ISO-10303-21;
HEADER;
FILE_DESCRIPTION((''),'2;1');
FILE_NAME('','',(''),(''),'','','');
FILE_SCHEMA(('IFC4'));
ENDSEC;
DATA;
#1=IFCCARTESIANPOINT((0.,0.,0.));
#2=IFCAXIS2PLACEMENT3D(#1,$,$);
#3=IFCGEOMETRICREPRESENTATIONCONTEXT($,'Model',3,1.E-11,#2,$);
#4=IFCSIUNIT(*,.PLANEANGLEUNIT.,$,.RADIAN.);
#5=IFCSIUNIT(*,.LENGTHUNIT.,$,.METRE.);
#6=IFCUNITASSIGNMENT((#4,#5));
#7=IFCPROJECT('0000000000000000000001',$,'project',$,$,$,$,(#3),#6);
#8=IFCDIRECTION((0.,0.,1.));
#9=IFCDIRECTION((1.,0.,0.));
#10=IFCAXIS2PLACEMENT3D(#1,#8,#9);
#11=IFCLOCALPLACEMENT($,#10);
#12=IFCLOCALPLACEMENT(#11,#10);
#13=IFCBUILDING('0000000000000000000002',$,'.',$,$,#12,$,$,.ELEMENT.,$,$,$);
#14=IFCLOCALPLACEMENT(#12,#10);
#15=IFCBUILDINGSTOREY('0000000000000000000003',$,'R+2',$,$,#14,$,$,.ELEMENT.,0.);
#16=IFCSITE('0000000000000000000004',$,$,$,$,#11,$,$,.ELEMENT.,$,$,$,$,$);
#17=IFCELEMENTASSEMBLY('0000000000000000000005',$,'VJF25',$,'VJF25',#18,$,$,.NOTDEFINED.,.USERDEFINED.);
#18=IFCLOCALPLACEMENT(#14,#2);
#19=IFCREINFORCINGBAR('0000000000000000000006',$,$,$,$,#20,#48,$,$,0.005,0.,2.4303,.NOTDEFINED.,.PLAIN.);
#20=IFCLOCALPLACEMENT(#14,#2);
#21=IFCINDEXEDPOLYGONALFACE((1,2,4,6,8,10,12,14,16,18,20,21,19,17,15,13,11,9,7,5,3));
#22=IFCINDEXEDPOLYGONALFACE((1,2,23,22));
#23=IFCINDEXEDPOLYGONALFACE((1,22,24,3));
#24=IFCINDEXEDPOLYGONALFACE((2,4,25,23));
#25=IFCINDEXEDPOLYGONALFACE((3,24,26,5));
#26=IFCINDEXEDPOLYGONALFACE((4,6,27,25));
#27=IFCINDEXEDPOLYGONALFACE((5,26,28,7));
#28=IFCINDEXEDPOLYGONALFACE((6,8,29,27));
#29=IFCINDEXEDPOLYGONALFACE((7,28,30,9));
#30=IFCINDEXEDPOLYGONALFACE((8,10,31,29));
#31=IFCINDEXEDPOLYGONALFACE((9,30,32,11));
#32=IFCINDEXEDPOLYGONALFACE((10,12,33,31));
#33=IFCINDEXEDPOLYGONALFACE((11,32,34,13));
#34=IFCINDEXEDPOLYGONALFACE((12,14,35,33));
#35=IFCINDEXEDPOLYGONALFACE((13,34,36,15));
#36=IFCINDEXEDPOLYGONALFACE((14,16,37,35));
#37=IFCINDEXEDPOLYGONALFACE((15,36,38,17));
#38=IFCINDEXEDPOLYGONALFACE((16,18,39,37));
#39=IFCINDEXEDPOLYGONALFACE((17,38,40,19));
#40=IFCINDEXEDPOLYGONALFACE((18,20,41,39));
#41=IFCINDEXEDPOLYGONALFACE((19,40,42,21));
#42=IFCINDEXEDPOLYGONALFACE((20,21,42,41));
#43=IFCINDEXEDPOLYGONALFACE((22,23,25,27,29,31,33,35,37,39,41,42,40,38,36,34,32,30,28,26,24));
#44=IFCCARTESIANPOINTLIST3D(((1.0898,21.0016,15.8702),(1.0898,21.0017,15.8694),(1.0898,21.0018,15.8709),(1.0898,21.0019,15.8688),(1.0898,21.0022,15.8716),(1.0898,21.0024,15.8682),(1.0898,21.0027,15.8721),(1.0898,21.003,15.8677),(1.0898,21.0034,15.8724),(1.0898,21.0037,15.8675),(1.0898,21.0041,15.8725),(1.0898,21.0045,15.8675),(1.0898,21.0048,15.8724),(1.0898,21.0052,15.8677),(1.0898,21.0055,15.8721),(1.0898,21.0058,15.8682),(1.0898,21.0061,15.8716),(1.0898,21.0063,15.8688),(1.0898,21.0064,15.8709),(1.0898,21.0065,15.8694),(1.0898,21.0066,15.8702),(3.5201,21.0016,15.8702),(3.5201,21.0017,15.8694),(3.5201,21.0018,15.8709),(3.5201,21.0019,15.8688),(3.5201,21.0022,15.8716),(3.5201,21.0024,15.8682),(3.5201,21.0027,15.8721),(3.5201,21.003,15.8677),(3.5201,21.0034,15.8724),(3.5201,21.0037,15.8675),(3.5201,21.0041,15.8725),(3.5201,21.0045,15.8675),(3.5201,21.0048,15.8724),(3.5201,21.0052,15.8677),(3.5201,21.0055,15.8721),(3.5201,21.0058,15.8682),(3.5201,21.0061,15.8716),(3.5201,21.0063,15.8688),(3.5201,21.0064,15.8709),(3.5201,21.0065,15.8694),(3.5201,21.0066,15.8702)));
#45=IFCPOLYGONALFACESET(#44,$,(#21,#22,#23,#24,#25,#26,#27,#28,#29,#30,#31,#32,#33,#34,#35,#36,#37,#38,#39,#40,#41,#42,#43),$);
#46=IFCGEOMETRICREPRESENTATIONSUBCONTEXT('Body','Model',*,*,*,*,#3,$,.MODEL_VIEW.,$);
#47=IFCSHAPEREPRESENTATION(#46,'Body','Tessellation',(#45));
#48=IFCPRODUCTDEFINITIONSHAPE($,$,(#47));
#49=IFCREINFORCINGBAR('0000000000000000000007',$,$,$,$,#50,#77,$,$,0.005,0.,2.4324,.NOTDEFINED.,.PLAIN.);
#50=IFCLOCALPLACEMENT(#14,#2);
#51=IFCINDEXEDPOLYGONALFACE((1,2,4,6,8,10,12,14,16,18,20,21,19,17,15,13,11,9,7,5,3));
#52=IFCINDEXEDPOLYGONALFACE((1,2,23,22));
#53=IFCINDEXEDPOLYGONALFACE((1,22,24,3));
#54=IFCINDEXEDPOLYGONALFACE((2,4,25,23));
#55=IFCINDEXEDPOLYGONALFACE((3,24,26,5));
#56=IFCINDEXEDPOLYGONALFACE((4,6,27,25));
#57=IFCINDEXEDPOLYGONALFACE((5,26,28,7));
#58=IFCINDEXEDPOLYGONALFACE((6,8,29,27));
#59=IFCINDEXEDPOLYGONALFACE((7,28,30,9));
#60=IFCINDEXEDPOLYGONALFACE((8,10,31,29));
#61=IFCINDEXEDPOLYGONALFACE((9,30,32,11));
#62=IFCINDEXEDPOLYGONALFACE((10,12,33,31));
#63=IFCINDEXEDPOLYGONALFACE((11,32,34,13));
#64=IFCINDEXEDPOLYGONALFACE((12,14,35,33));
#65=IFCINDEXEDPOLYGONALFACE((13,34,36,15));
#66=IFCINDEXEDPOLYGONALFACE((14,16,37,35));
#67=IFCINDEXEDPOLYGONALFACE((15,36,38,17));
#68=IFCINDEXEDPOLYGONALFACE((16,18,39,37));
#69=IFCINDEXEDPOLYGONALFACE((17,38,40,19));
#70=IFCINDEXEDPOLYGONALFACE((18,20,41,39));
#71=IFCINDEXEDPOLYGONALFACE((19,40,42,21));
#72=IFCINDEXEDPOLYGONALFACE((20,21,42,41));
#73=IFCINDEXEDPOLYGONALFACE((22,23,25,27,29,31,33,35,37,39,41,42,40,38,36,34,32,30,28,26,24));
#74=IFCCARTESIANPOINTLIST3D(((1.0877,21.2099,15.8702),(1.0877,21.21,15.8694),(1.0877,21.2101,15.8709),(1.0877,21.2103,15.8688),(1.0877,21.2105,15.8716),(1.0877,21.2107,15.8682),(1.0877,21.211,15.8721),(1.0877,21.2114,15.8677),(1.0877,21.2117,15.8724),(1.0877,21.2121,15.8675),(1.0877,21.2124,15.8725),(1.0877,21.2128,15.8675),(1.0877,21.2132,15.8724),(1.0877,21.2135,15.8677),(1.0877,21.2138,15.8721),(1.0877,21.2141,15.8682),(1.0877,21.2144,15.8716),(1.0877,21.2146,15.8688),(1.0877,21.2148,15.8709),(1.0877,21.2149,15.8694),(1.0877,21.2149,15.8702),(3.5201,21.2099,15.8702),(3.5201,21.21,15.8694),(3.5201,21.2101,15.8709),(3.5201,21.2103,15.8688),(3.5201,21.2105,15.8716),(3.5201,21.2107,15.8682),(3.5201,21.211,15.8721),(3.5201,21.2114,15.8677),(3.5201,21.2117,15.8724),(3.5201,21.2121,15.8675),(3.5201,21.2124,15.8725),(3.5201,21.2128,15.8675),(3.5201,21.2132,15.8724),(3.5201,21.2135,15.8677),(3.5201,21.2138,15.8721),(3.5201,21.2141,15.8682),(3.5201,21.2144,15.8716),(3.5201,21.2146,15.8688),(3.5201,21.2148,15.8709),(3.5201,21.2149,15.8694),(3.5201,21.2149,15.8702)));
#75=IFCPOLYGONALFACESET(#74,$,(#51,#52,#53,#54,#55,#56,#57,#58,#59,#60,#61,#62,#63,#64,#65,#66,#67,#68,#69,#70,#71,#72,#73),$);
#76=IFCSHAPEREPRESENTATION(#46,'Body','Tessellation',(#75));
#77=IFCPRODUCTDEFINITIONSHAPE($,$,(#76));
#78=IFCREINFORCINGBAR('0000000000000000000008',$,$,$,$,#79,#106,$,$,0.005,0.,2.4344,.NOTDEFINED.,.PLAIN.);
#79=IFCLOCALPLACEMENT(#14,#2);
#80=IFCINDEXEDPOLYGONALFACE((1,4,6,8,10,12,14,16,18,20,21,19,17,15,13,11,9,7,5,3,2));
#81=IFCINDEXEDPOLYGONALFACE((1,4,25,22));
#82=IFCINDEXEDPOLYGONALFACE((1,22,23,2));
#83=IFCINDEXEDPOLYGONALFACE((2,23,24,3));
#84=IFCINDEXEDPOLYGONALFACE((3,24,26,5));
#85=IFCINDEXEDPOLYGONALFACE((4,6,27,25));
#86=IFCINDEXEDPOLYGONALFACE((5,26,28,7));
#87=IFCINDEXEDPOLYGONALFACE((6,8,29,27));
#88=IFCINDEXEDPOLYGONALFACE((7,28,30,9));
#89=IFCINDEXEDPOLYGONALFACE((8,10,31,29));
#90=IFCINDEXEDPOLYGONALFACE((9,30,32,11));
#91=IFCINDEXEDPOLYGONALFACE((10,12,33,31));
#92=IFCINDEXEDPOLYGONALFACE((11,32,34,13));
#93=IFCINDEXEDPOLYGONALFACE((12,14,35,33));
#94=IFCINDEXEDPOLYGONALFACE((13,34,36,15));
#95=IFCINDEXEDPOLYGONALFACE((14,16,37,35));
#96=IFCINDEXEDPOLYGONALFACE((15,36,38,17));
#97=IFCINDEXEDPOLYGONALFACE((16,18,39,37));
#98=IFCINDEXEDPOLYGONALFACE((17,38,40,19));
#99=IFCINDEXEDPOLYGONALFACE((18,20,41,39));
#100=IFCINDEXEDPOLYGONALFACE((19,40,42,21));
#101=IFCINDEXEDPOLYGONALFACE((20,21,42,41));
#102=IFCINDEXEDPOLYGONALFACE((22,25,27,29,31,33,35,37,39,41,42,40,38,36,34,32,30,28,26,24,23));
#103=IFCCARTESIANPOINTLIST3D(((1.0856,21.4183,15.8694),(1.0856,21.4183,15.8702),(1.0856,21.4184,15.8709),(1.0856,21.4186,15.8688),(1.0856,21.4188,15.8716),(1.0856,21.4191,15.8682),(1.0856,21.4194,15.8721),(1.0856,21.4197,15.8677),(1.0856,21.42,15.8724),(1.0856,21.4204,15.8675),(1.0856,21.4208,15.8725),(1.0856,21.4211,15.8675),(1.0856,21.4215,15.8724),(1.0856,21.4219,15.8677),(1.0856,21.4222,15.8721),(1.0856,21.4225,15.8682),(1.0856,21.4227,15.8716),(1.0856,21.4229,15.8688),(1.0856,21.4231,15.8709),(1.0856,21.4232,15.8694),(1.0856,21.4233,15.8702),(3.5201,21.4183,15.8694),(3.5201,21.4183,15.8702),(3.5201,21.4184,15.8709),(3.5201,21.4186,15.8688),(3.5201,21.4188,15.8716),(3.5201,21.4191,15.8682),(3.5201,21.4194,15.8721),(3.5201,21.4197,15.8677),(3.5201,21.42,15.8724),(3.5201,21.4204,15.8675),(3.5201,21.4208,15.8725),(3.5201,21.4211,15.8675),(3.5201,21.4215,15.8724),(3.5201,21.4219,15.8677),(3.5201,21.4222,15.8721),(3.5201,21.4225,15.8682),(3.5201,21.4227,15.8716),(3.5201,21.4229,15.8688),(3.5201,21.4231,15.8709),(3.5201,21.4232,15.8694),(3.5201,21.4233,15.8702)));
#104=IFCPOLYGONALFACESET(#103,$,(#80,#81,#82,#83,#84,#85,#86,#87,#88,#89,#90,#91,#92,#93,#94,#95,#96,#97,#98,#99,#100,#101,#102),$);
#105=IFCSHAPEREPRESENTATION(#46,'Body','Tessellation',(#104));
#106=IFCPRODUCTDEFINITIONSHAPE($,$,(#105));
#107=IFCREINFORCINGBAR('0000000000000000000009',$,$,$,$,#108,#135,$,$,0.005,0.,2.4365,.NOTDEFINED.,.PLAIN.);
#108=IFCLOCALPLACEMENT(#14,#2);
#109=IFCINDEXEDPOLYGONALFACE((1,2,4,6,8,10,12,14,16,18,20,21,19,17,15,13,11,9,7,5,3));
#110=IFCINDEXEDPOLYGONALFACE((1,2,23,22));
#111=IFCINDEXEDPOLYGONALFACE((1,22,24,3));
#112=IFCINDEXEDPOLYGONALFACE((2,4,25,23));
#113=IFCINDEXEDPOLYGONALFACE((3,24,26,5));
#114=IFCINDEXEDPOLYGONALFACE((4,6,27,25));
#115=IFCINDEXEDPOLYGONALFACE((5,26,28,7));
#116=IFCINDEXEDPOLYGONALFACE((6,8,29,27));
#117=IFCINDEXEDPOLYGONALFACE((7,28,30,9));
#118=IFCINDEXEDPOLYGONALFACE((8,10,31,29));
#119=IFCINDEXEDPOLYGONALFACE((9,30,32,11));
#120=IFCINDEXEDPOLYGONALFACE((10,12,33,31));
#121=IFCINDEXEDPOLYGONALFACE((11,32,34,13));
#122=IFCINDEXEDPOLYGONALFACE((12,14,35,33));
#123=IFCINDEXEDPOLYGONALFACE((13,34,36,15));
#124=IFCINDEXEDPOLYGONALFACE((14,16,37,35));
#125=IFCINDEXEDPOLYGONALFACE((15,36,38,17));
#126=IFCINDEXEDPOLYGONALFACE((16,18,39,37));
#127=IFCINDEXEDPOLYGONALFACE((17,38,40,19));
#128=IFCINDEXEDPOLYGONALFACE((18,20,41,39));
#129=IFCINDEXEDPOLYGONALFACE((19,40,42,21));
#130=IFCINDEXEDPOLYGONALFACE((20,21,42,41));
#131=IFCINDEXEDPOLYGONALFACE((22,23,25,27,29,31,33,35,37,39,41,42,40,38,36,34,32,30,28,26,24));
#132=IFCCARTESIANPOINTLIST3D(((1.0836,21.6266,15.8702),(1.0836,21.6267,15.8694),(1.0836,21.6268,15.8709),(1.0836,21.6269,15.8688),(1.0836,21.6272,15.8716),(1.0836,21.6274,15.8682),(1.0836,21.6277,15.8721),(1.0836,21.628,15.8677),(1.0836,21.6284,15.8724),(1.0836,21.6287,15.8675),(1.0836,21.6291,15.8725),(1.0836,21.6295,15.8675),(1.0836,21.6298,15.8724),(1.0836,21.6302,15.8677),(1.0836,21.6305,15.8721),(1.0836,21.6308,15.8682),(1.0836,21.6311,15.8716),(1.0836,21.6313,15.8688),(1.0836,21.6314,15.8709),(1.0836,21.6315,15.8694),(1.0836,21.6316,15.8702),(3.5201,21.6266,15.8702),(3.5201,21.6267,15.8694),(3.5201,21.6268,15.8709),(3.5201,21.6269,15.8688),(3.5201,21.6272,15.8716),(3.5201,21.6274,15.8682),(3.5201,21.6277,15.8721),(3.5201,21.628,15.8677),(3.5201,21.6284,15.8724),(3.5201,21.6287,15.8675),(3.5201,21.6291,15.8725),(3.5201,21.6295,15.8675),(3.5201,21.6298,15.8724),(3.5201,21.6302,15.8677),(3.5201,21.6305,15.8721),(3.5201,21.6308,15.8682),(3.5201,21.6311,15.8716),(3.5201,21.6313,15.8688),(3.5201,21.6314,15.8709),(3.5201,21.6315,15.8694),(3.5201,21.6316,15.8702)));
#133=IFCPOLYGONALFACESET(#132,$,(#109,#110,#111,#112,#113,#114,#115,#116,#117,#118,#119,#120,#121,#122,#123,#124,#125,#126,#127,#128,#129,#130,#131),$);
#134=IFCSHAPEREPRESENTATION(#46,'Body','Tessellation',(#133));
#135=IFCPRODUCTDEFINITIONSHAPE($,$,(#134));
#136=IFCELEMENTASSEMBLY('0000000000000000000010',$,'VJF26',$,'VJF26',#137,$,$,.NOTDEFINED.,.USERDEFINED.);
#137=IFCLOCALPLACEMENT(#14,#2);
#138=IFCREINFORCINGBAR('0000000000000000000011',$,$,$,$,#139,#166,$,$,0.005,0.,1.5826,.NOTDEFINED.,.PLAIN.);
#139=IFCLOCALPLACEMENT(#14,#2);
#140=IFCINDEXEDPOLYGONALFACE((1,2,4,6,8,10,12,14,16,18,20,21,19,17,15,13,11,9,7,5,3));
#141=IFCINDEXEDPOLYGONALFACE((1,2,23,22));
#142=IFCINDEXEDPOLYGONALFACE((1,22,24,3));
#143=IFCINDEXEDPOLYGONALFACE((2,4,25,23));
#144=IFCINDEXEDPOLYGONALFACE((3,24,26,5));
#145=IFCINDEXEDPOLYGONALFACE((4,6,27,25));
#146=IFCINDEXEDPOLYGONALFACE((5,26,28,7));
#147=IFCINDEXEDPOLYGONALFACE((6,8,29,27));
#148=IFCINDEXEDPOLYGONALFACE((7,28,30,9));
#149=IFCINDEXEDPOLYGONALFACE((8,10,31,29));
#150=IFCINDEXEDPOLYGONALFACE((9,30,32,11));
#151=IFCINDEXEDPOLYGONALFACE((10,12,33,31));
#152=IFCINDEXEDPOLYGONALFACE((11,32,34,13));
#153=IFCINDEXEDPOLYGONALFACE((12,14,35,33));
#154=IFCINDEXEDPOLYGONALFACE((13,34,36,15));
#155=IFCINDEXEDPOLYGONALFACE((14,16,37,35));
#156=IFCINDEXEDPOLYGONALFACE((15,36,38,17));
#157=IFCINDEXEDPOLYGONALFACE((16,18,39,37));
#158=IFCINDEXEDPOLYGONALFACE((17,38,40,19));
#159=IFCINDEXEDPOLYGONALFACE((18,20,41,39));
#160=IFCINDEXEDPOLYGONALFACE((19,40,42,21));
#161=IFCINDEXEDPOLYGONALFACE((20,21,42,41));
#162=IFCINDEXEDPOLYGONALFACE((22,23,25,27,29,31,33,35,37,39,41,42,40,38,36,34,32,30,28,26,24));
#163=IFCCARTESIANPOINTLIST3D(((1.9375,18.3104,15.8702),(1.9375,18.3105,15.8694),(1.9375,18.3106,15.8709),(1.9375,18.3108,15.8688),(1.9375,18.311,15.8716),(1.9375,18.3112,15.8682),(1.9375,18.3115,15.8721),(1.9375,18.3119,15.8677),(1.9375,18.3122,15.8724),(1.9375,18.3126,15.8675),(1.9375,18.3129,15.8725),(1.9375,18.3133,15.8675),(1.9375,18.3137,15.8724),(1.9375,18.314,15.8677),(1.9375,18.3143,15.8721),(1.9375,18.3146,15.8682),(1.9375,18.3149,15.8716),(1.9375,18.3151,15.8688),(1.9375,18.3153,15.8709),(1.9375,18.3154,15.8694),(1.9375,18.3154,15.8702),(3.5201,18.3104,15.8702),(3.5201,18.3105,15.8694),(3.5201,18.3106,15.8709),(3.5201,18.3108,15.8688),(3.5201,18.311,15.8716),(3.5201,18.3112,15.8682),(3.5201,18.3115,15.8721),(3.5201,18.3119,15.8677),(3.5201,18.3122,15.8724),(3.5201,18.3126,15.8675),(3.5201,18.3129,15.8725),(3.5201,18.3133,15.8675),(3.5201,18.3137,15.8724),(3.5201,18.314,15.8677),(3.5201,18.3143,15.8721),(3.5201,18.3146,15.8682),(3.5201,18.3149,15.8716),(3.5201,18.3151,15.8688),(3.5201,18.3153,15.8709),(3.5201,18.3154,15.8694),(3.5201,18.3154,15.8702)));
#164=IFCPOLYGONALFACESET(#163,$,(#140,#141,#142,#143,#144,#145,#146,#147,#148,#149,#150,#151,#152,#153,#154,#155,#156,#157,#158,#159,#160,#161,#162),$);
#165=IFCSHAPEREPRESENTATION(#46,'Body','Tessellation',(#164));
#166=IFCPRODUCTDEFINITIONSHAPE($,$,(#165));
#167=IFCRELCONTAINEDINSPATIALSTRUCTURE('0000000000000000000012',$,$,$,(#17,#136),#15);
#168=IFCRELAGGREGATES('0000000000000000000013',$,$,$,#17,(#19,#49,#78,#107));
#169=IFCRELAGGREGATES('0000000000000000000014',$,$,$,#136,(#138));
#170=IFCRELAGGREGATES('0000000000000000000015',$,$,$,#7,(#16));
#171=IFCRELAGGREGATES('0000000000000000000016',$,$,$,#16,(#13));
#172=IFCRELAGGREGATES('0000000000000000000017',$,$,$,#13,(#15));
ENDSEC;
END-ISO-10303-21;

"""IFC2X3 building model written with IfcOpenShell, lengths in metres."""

from ifc_helpers import new_model, entity, si_unit, origin, origin_with_axes, place, context, subcontext, project, spatial, shape, element, aggregate, save


model = new_model("IFC2X3")

# Units and contexts
model_context = context("Model", 3, precision=1e-11, world=origin())
body_context = subcontext(model_context, "Body", "Model", "MODEL_VIEW")
ifc_project = project(units=[si_unit("PLANEANGLEUNIT", "RADIAN"), si_unit("LENGTHUNIT", "METRE")], contexts=[model_context])

# Site, building, storey
site_placement = place(None, origin_with_axes())
site = spatial("IfcSite", under=ifc_project, at=site_placement, CompositionType="ELEMENT")
building_placement = place(site_placement, origin_with_axes())
building = spatial("IfcBuilding", under=site, at=building_placement, Name=".", CompositionType="ELEMENT")
storey_placement = place(building_placement, origin_with_axes())
storey = spatial("IfcBuildingStorey", under=building, at=storey_placement, Name="R+2", CompositionType="ELEMENT", Elevation=0.0)

# Element assemblies, reinforcing bars
assembly_1_placement = place(storey_placement, origin_with_axes())
assembly_1 = element("IfcElementAssembly", 1, at=assembly_1_placement, inside=storey, Name="VJF25", ObjectType="VJF25", AssemblyPlace="NOTDEFINED", PredefinedType="USERDEFINED")
reinforcing_bar_1_placement = place(assembly_1_placement, origin_with_axes())
reinforcing_bar_1 = element("IfcReinforcingBar", 2, at=reinforcing_bar_1_placement, BarLength=2.4303, BarRole="NOTDEFINED", BarSurface="PLAIN", CrossSectionArea=0.0, NominalDiameter=0.005, shapes=[
    shape(body_context, "Body", "AdvancedSweptSolid", [entity("IfcSweptDiskSolid", entity("IfcPolyline", [entity("IfcCartesianPoint", [1.0898, 21.0041, 15.87]), entity("IfcCartesianPoint", [3.5201, 21.0041, 15.87])]), 0.0025, None, 0.0, 2.4303)]),
    shape(body_context, "Body", "AdvancedSweptSolid", [entity("IfcSweptDiskSolid", entity("IfcPolyline", [entity("IfcCartesianPoint", [1.0898, 21.0041, 15.87]), entity("IfcCartesianPoint", [3.5201, 21.0041, 15.87])]), 0.0025, None, 0.0, 2.4303)]),
])
reinforcing_bar_2_placement = place(assembly_1_placement, origin_with_axes())
reinforcing_bar_2 = element("IfcReinforcingBar", 3, at=reinforcing_bar_2_placement, BarLength=2.4324, BarRole="NOTDEFINED", BarSurface="PLAIN", CrossSectionArea=0.0, NominalDiameter=0.005, shapes=[
    shape(body_context, "Body", "AdvancedSweptSolid", [entity("IfcSweptDiskSolid", entity("IfcPolyline", [entity("IfcCartesianPoint", [1.0877, 21.2124, 15.87]), entity("IfcCartesianPoint", [3.5201, 21.2124, 15.87])]), 0.0025, None, 0.0, 2.4324)]),
    shape(body_context, "Body", "AdvancedSweptSolid", [entity("IfcSweptDiskSolid", entity("IfcPolyline", [entity("IfcCartesianPoint", [1.0877, 21.2124, 15.87]), entity("IfcCartesianPoint", [3.5201, 21.2124, 15.87])]), 0.0025, None, 0.0, 2.4324)]),
])
reinforcing_bar_3_placement = place(assembly_1_placement, origin_with_axes())
reinforcing_bar_3 = element("IfcReinforcingBar", 4, at=reinforcing_bar_3_placement, BarLength=2.4344, BarRole="NOTDEFINED", BarSurface="PLAIN", CrossSectionArea=0.0, NominalDiameter=0.005, shapes=[
    shape(body_context, "Body", "AdvancedSweptSolid", [entity("IfcSweptDiskSolid", entity("IfcPolyline", [entity("IfcCartesianPoint", [1.0856, 21.4208, 15.87]), entity("IfcCartesianPoint", [3.5201, 21.4208, 15.87])]), 0.0025, None, 0.0, 2.4344)]),
    shape(body_context, "Body", "AdvancedSweptSolid", [entity("IfcSweptDiskSolid", entity("IfcPolyline", [entity("IfcCartesianPoint", [1.0856, 21.4208, 15.87]), entity("IfcCartesianPoint", [3.5201, 21.4208, 15.87])]), 0.0025, None, 0.0, 2.4344)]),
])
reinforcing_bar_4_placement = place(assembly_1_placement, origin_with_axes())
reinforcing_bar_4 = element("IfcReinforcingBar", 5, at=reinforcing_bar_4_placement, BarLength=2.4365, BarRole="NOTDEFINED", BarSurface="PLAIN", CrossSectionArea=0.0, NominalDiameter=0.005, shapes=[
    shape(body_context, "Body", "AdvancedSweptSolid", [entity("IfcSweptDiskSolid", entity("IfcPolyline", [entity("IfcCartesianPoint", [1.0836, 21.6291, 15.87]), entity("IfcCartesianPoint", [3.5201, 21.6291, 15.87])]), 0.0025, None, 0.0, 2.4365)]),
    shape(body_context, "Body", "AdvancedSweptSolid", [entity("IfcSweptDiskSolid", entity("IfcPolyline", [entity("IfcCartesianPoint", [1.0836, 21.6291, 15.87]), entity("IfcCartesianPoint", [3.5201, 21.6291, 15.87])]), 0.0025, None, 0.0, 2.4365)]),
])
aggregate(assembly_1, [reinforcing_bar_1, reinforcing_bar_2, reinforcing_bar_3, reinforcing_bar_4])
assembly_2_placement = place(storey_placement, origin_with_axes())
assembly_2 = element("IfcElementAssembly", 6, at=assembly_2_placement, inside=storey, Name="VJF26", ObjectType="VJF26", AssemblyPlace="NOTDEFINED", PredefinedType="USERDEFINED")
reinforcing_bar_5_placement = place(assembly_2_placement, origin_with_axes())
reinforcing_bar_5 = element("IfcReinforcingBar", 7, at=reinforcing_bar_5_placement, BarLength=1.5826, BarRole="NOTDEFINED", BarSurface="PLAIN", CrossSectionArea=0.0, NominalDiameter=0.005, shapes=[
    shape(body_context, "Body", "AdvancedSweptSolid", [entity("IfcSweptDiskSolid", entity("IfcPolyline", [entity("IfcCartesianPoint", [1.9375, 18.3129, 15.87]), entity("IfcCartesianPoint", [3.5201, 18.3129, 15.87])]), 0.0025, None, 0.0, 1.5826)]),
    shape(body_context, "Body", "AdvancedSweptSolid", [entity("IfcSweptDiskSolid", entity("IfcPolyline", [entity("IfcCartesianPoint", [1.9375, 18.3129, 15.87]), entity("IfcCartesianPoint", [3.5201, 18.3129, 15.87])]), 0.0025, None, 0.0, 1.5826)]),
])
aggregate(assembly_2, [reinforcing_bar_5])

save(model, "model.ifc")
